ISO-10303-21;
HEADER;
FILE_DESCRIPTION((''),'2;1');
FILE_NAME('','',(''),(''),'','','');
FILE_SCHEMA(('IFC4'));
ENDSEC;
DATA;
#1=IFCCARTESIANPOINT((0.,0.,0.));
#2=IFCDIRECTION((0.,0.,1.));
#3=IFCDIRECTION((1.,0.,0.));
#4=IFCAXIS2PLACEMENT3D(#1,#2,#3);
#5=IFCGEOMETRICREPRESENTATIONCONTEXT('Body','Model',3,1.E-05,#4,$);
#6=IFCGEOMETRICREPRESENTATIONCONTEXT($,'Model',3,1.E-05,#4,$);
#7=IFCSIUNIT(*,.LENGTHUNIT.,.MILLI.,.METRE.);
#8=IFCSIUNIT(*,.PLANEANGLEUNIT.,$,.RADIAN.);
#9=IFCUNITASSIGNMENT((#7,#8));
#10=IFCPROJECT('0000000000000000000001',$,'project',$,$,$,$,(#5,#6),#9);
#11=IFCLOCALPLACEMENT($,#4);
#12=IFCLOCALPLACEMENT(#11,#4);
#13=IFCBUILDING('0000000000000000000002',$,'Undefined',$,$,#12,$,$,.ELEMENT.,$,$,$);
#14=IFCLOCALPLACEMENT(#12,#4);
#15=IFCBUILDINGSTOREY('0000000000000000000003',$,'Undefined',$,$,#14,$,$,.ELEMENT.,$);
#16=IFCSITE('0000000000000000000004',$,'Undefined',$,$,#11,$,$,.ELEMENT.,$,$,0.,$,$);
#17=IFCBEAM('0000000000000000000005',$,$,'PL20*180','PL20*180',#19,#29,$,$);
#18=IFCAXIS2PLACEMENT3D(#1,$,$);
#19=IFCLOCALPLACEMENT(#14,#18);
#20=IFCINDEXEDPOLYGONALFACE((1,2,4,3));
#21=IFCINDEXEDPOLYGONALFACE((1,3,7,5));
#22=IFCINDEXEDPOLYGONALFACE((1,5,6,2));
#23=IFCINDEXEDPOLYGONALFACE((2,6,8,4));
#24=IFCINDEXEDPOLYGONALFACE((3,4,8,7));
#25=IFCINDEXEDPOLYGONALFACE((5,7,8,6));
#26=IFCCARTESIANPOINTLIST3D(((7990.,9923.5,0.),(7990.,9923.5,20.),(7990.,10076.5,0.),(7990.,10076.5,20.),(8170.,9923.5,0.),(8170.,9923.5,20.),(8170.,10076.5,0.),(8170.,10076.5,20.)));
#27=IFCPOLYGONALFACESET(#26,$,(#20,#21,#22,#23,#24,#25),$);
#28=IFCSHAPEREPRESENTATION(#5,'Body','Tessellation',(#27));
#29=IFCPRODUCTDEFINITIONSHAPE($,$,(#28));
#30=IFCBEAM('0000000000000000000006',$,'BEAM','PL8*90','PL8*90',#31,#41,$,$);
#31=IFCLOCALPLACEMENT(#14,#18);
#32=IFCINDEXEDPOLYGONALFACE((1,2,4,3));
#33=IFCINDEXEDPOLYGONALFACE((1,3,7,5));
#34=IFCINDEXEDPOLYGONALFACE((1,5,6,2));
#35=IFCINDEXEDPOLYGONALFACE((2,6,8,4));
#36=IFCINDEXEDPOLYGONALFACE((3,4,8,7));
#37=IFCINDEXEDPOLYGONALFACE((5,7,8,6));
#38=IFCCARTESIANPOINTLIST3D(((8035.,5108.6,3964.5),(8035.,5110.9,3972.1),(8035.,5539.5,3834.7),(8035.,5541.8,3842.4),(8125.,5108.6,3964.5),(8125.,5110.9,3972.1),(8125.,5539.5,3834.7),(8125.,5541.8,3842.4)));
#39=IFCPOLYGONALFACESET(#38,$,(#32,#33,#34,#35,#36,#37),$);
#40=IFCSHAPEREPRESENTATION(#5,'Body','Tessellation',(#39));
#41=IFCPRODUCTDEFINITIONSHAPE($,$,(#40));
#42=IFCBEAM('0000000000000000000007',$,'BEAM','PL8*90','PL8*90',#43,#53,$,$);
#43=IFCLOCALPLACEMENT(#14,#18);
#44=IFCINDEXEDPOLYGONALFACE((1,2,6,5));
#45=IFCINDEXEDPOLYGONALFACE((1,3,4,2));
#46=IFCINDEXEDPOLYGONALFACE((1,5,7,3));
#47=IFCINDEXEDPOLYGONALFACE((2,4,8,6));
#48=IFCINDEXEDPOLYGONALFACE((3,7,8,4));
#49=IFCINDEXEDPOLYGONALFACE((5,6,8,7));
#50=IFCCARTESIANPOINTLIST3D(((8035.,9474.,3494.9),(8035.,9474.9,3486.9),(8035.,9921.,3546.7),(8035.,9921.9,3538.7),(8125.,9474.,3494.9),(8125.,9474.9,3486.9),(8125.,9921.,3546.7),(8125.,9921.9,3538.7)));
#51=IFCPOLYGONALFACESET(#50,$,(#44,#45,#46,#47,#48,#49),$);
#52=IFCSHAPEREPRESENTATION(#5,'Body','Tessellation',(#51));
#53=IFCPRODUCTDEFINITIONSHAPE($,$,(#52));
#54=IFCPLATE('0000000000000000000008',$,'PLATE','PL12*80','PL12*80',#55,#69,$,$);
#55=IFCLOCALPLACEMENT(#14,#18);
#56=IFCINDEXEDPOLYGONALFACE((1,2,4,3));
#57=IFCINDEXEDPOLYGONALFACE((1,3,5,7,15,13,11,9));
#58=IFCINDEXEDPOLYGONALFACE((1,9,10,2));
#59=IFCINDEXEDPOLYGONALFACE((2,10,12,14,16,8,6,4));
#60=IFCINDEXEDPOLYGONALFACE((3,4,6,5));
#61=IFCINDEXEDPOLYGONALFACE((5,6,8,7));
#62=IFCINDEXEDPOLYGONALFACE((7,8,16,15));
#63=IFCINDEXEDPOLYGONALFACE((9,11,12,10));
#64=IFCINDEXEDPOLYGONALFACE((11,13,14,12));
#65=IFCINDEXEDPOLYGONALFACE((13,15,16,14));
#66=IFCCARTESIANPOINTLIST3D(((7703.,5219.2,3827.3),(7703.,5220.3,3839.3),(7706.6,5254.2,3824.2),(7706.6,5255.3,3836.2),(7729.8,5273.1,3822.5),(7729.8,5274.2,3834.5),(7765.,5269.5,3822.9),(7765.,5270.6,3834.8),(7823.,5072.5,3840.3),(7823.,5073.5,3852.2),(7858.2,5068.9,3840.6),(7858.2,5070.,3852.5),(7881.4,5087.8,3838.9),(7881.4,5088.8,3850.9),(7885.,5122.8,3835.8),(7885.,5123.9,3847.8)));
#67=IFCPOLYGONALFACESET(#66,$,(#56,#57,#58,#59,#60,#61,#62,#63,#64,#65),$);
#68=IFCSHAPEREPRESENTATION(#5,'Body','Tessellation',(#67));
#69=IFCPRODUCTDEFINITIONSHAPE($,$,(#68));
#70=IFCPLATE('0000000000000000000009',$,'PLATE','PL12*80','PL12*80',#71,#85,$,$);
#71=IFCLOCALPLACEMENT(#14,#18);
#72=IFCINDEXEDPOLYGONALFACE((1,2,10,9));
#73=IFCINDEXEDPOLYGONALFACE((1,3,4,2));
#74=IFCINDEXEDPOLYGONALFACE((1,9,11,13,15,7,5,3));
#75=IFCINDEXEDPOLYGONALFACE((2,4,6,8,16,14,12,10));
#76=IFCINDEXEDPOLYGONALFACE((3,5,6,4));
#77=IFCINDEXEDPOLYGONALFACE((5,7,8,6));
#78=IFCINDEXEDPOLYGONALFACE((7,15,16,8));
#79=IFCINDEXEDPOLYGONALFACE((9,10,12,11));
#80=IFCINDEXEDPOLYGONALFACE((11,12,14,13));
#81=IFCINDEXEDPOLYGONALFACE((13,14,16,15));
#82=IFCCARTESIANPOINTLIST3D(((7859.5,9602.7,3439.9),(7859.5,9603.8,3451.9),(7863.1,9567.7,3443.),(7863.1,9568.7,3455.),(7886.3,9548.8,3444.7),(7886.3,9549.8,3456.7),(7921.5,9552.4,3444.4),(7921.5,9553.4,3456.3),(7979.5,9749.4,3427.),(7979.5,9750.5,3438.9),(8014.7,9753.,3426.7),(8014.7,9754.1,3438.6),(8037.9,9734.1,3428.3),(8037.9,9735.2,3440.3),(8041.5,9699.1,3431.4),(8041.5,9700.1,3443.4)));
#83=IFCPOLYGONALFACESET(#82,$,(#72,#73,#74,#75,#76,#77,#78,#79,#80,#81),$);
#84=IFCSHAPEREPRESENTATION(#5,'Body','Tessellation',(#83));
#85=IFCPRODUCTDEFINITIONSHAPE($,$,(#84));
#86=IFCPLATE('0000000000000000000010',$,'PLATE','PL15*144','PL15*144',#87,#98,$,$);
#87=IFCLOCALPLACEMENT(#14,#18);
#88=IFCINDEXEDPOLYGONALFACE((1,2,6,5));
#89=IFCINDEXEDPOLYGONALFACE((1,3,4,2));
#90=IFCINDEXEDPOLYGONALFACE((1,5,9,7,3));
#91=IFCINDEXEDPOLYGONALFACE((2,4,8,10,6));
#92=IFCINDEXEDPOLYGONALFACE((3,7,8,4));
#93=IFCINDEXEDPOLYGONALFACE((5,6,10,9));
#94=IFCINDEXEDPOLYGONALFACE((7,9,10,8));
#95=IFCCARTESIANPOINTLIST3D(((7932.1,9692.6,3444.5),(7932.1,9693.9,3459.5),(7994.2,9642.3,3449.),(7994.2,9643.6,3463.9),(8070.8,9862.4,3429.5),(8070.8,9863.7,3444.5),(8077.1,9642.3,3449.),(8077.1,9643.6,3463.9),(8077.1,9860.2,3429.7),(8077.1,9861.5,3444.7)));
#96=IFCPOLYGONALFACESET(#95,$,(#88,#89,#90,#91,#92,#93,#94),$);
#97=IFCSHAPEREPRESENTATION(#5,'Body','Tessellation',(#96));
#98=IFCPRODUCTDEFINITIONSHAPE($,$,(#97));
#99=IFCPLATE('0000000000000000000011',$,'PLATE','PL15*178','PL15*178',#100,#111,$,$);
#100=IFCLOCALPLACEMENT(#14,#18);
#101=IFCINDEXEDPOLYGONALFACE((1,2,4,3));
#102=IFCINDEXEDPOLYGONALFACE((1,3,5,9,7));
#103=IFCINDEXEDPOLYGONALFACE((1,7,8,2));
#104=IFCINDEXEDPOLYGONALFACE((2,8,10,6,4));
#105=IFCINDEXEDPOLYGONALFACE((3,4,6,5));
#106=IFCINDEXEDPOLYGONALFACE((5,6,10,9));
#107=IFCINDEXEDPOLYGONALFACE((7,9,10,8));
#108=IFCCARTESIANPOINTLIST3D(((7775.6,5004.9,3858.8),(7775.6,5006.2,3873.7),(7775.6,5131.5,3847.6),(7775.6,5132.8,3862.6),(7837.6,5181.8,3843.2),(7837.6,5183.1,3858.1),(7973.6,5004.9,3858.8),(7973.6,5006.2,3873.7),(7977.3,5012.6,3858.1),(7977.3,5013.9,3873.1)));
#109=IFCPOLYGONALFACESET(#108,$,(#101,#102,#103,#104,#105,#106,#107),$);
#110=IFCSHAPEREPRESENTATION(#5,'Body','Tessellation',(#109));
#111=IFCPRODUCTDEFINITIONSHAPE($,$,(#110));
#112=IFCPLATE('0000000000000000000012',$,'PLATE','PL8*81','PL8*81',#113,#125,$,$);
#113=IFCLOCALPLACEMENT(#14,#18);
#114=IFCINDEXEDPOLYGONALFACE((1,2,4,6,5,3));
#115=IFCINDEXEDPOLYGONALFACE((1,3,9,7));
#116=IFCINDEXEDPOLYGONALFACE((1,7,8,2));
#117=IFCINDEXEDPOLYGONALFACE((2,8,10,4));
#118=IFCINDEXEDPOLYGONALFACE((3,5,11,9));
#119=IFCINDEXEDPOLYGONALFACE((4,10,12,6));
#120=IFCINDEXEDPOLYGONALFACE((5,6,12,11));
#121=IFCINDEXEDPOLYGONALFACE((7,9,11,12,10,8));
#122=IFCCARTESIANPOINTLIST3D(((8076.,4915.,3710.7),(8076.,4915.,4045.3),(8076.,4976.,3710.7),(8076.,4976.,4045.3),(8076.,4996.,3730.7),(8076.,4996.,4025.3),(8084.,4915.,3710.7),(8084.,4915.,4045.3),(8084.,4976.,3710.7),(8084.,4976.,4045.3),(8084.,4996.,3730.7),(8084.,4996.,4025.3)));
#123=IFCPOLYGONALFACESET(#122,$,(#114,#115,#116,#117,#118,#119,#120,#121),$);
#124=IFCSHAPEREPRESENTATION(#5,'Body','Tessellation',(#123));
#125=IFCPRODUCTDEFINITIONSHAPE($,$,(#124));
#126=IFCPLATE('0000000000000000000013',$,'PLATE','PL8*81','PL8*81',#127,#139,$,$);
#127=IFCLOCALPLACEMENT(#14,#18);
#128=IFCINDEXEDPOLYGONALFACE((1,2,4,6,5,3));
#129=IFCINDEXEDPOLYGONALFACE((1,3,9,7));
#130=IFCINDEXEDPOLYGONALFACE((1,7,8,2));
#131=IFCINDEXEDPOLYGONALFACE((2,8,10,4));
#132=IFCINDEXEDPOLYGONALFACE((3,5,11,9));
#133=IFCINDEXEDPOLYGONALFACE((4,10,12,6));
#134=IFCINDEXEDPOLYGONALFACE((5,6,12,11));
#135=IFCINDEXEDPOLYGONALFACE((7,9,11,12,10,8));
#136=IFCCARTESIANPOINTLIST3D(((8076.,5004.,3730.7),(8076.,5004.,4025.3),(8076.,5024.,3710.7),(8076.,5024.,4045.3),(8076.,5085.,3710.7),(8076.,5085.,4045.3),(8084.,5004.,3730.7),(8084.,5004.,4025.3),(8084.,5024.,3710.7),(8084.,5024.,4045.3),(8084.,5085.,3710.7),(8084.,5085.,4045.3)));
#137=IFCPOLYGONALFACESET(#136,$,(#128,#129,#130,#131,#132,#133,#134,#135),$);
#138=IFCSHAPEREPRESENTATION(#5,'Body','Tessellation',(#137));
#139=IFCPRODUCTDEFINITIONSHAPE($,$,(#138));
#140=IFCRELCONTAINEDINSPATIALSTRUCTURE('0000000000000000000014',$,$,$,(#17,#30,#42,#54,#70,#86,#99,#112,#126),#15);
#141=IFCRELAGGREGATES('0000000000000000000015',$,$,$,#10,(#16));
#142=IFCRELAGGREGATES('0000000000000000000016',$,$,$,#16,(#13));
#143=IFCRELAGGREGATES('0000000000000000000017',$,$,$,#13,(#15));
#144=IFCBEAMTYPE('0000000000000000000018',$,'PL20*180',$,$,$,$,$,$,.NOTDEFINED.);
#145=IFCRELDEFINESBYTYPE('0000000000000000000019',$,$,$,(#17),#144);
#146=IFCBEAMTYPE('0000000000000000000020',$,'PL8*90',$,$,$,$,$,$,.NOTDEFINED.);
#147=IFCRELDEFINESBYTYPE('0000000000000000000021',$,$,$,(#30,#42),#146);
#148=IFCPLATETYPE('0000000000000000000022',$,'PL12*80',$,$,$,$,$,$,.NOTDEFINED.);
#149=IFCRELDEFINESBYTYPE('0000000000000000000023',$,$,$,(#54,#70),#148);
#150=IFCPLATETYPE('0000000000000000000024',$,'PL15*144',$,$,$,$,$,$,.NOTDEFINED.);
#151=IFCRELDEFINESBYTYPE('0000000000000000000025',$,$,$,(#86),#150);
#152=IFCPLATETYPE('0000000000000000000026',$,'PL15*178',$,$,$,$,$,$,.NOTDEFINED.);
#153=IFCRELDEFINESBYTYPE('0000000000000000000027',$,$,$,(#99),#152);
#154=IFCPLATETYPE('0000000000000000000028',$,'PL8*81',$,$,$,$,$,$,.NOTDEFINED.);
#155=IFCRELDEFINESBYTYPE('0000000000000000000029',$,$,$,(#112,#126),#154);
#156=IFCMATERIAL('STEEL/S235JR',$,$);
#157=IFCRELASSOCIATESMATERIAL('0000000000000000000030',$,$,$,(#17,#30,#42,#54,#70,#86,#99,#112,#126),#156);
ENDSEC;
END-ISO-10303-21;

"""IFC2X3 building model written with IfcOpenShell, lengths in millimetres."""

from ifc_helpers import new_model, si_unit, frame, origin_with_axes, origin_2d_with_axis, place, context, project, spatial, polyline, rectangle, outline, extrude, material, type_object, element, save


model = new_model("IFC2X3")

# Units and contexts
model_context_1 = context("Model", 3, precision=1e-05, world=origin_with_axes(), identifier="Body")
model_context_2 = context("Model", 3, precision=1e-05, world=origin_with_axes())
ifc_project = project(units=[si_unit("LENGTHUNIT", "METRE", prefix="MILLI"), si_unit("PLANEANGLEUNIT", "RADIAN")], contexts=[model_context_1, model_context_2])

# Site, building, storey
site_placement = place(None, origin_with_axes())
site = spatial("IfcSite", under=ifc_project, at=site_placement, Name="Undefined", CompositionType="ELEMENT", RefElevation=0.0)
building_placement = place(site_placement, origin_with_axes())
building = spatial("IfcBuilding", under=site, at=building_placement, Name="Undefined", CompositionType="ELEMENT")
storey_placement = place(building_placement, origin_with_axes())
storey = spatial("IfcBuildingStorey", under=building, at=storey_placement, Name="Undefined", CompositionType="ELEMENT")

# Shared definitions
ifc_material = material(Name="STEEL/S235JR")

# Beams
beam_type_1 = type_object("IfcBeamType", Name="PL20*180", PredefinedType="NOTDEFINED")
beam_1_placement = place(storey_placement, frame((8080.0, 9923.5, 10.0), z_axis=(-1.0, 0.0, 0.0), x_axis=(0.0, 1.0, 0.0)))
element("IfcBeam", 1, at=beam_1_placement, inside=storey, type_object=beam_type_1, material=ifc_material, Description="PL20*180", ObjectType="PL20*180", context=model_context_1, shape_type="SweptSolid", body=[
    extrude(rectangle(XDim=20.0, YDim=180.0, at=origin_2d_with_axis()), frame((153.0, 0.0, 0.0), z_axis=(-1.0, 0.0, 0.0), x_axis=(0.0, -1.0, 0.0)), (0.0, 0.0, 1.0), 153.0),
])
beam_type_2 = type_object("IfcBeamType", Name="PL8*90", PredefinedType="NOTDEFINED")
beam_2_placement = place(storey_placement, frame((8080.0, 5109.8, 3968.3), z_axis=(1.0, 0.0, 0.0), x_axis=(0.0, 0.957545, -0.288283)))
element("IfcBeam", 2, at=beam_2_placement, inside=storey, type_object=beam_type_2, material=ifc_material, Name="BEAM", Description="PL8*90", ObjectType="PL8*90", context=model_context_1, shape_type="SweptSolid", body=[
    extrude(rectangle(XDim=8.0, YDim=90.0, at=origin_2d_with_axis()), frame((450.0, 0.0, 0.0), z_axis=(-1.0, 0.0, 0.0), x_axis=(0.0, -1.0, 0.0)), (0.0, 0.0, 1.0), 450.0),
])
beam_3_placement = place(storey_placement, frame((8080.0, 9921.4, 3542.7), z_axis=(1.0, 0.0, 0.0), x_axis=(0.0, -0.993355, -0.115087)))
element("IfcBeam", 3, at=beam_3_placement, inside=storey, type_object=beam_type_2, material=ifc_material, Name="BEAM", Description="PL8*90", ObjectType="PL8*90", context=model_context_1, shape_type="SweptSolid", body=[
    extrude(rectangle(XDim=8.0, YDim=90.0, at=origin_2d_with_axis()), frame((450.0, 0.0, 0.0), z_axis=(-1.0, 0.0, 0.0), x_axis=(0.0, -1.0, 0.0)), (0.0, 0.0, 1.0), 450.0),
])

# Plates
plate_type_1 = type_object("IfcPlateType", Name="PL12*80", PredefinedType="NOTDEFINED")
for number, where, z_axis, x_axis, name in (
    (4, (7838.8, 5053.7, 3848.0), (-0.000001, 0.088031, 0.996118), (0.775235, 0.629221, -0.055604), "PLATE"),
    (5, (7905.7, 9533.6, 3452.1), (0.0, -0.088027, -0.996118), (-0.775235, 0.629221, -0.055606), "PLATE"),
):
    element("IfcPlate", number, at=place(storey_placement, frame(where, z_axis=z_axis, x_axis=x_axis)), inside=storey, type_object=plate_type_1, material=ifc_material, Name=name, Description="PL12*80", ObjectType="PL12*80", context=model_context_1, shape_type="SweptSolid", body=[
        extrude(outline(polyline([(0.0, 25.0), (25.0, 0.0), (55.0, 0.0), (80.0, 25.0), (80.0, 215.0), (55.0, 240.0), (25.0, 240.0), (0.0, 215.0), (0.0, 25.0)])), frame((0.0, 0.0, -6.0), z_axis=(0.0, 0.0, 1.0), x_axis=(1.0, 0.0, 0.0)), (0.0, 0.0, 1.0), 12.0),
    ])
plate_type_2 = type_object("IfcPlateType", Name="PL15*144", PredefinedType="NOTDEFINED")
plate_1_placement = place(storey_placement, frame((8077.1, 9642.9, 3456.5), z_axis=(0.00002, 0.08801, 0.99612), x_axis=(0.0, 0.99612, -0.08801)))
element("IfcPlate", 6, at=plate_1_placement, inside=storey, type_object=plate_type_2, material=ifc_material, Name="PLATE", Description="PL15*144", ObjectType="PL15*144", context=model_context_1, shape_type="SweptSolid", body=[
    extrude(outline(polyline([(0.0, 0.0), (218.8, 0.0), (221.0, 6.3), (50.5, 145.0), (0.0, 82.9), (0.0, 0.0)])), frame((0.0, 0.0, -7.5), z_axis=(0.0, 0.0, 1.0), x_axis=(1.0, 0.0, 0.0)), (0.0, 0.0, 1.0), 15.0),
])
plate_type_3 = type_object("IfcPlateType", Name="PL15*178", PredefinedType="NOTDEFINED")
plate_2_placement = place(storey_placement, frame((7775.6, 5005.6, 3866.3), z_axis=(-0.000001, 0.088031, 0.996118), x_axis=(1.0, 0.0, 0.0)))
element("IfcPlate", 7, at=plate_2_placement, inside=storey, type_object=plate_type_3, material=ifc_material, Name="PLATE", Description="PL15*178", ObjectType="PL15*178", context=model_context_1, shape_type="SweptSolid", body=[
    extrude(outline(polyline([(0.0, 0.0), (198.0, 0.0), (201.7, 7.7), (62.0, 177.6), (0.0, 127.1), (0.0, 0.0)])), frame((0.0, 0.0, -7.5), z_axis=(0.0, 0.0, 1.0), x_axis=(1.0, 0.0, 0.0)), (0.0, 0.0, 1.0), 15.0),
])
plate_type_4 = type_object("IfcPlateType", Name="PL8*81", PredefinedType="NOTDEFINED")
for number, where, z_axis, x_axis, name in (
    (8, (8080.0, 4996.0, 3710.7), (-1.0, 0.0, 0.0), (0.0, -1.0, 0.0), "PLATE"),
    (9, (8080.0, 5004.0, 3710.7), (1.0, 0.0, 0.0), (0.0, 1.0, 0.0), "PLATE"),
):
    element("IfcPlate", number, at=place(storey_placement, frame(where, z_axis=z_axis, x_axis=x_axis)), inside=storey, type_object=plate_type_4, material=ifc_material, Name=name, Description="PL8*81", ObjectType="PL8*81", context=model_context_1, shape_type="SweptSolid", body=[
        extrude(outline(polyline([(0.0, 20.0), (20.0, 0.0), (81.0, 0.0), (81.0, 334.6), (20.0, 334.6), (0.0, 314.6), (0.0, 20.0)])), frame((0.0, 0.0, -4.0), z_axis=(0.0, 0.0, 1.0), x_axis=(1.0, 0.0, 0.0)), (0.0, 0.0, 1.0), 8.0),
    ])

save(model, "model.ifc")
